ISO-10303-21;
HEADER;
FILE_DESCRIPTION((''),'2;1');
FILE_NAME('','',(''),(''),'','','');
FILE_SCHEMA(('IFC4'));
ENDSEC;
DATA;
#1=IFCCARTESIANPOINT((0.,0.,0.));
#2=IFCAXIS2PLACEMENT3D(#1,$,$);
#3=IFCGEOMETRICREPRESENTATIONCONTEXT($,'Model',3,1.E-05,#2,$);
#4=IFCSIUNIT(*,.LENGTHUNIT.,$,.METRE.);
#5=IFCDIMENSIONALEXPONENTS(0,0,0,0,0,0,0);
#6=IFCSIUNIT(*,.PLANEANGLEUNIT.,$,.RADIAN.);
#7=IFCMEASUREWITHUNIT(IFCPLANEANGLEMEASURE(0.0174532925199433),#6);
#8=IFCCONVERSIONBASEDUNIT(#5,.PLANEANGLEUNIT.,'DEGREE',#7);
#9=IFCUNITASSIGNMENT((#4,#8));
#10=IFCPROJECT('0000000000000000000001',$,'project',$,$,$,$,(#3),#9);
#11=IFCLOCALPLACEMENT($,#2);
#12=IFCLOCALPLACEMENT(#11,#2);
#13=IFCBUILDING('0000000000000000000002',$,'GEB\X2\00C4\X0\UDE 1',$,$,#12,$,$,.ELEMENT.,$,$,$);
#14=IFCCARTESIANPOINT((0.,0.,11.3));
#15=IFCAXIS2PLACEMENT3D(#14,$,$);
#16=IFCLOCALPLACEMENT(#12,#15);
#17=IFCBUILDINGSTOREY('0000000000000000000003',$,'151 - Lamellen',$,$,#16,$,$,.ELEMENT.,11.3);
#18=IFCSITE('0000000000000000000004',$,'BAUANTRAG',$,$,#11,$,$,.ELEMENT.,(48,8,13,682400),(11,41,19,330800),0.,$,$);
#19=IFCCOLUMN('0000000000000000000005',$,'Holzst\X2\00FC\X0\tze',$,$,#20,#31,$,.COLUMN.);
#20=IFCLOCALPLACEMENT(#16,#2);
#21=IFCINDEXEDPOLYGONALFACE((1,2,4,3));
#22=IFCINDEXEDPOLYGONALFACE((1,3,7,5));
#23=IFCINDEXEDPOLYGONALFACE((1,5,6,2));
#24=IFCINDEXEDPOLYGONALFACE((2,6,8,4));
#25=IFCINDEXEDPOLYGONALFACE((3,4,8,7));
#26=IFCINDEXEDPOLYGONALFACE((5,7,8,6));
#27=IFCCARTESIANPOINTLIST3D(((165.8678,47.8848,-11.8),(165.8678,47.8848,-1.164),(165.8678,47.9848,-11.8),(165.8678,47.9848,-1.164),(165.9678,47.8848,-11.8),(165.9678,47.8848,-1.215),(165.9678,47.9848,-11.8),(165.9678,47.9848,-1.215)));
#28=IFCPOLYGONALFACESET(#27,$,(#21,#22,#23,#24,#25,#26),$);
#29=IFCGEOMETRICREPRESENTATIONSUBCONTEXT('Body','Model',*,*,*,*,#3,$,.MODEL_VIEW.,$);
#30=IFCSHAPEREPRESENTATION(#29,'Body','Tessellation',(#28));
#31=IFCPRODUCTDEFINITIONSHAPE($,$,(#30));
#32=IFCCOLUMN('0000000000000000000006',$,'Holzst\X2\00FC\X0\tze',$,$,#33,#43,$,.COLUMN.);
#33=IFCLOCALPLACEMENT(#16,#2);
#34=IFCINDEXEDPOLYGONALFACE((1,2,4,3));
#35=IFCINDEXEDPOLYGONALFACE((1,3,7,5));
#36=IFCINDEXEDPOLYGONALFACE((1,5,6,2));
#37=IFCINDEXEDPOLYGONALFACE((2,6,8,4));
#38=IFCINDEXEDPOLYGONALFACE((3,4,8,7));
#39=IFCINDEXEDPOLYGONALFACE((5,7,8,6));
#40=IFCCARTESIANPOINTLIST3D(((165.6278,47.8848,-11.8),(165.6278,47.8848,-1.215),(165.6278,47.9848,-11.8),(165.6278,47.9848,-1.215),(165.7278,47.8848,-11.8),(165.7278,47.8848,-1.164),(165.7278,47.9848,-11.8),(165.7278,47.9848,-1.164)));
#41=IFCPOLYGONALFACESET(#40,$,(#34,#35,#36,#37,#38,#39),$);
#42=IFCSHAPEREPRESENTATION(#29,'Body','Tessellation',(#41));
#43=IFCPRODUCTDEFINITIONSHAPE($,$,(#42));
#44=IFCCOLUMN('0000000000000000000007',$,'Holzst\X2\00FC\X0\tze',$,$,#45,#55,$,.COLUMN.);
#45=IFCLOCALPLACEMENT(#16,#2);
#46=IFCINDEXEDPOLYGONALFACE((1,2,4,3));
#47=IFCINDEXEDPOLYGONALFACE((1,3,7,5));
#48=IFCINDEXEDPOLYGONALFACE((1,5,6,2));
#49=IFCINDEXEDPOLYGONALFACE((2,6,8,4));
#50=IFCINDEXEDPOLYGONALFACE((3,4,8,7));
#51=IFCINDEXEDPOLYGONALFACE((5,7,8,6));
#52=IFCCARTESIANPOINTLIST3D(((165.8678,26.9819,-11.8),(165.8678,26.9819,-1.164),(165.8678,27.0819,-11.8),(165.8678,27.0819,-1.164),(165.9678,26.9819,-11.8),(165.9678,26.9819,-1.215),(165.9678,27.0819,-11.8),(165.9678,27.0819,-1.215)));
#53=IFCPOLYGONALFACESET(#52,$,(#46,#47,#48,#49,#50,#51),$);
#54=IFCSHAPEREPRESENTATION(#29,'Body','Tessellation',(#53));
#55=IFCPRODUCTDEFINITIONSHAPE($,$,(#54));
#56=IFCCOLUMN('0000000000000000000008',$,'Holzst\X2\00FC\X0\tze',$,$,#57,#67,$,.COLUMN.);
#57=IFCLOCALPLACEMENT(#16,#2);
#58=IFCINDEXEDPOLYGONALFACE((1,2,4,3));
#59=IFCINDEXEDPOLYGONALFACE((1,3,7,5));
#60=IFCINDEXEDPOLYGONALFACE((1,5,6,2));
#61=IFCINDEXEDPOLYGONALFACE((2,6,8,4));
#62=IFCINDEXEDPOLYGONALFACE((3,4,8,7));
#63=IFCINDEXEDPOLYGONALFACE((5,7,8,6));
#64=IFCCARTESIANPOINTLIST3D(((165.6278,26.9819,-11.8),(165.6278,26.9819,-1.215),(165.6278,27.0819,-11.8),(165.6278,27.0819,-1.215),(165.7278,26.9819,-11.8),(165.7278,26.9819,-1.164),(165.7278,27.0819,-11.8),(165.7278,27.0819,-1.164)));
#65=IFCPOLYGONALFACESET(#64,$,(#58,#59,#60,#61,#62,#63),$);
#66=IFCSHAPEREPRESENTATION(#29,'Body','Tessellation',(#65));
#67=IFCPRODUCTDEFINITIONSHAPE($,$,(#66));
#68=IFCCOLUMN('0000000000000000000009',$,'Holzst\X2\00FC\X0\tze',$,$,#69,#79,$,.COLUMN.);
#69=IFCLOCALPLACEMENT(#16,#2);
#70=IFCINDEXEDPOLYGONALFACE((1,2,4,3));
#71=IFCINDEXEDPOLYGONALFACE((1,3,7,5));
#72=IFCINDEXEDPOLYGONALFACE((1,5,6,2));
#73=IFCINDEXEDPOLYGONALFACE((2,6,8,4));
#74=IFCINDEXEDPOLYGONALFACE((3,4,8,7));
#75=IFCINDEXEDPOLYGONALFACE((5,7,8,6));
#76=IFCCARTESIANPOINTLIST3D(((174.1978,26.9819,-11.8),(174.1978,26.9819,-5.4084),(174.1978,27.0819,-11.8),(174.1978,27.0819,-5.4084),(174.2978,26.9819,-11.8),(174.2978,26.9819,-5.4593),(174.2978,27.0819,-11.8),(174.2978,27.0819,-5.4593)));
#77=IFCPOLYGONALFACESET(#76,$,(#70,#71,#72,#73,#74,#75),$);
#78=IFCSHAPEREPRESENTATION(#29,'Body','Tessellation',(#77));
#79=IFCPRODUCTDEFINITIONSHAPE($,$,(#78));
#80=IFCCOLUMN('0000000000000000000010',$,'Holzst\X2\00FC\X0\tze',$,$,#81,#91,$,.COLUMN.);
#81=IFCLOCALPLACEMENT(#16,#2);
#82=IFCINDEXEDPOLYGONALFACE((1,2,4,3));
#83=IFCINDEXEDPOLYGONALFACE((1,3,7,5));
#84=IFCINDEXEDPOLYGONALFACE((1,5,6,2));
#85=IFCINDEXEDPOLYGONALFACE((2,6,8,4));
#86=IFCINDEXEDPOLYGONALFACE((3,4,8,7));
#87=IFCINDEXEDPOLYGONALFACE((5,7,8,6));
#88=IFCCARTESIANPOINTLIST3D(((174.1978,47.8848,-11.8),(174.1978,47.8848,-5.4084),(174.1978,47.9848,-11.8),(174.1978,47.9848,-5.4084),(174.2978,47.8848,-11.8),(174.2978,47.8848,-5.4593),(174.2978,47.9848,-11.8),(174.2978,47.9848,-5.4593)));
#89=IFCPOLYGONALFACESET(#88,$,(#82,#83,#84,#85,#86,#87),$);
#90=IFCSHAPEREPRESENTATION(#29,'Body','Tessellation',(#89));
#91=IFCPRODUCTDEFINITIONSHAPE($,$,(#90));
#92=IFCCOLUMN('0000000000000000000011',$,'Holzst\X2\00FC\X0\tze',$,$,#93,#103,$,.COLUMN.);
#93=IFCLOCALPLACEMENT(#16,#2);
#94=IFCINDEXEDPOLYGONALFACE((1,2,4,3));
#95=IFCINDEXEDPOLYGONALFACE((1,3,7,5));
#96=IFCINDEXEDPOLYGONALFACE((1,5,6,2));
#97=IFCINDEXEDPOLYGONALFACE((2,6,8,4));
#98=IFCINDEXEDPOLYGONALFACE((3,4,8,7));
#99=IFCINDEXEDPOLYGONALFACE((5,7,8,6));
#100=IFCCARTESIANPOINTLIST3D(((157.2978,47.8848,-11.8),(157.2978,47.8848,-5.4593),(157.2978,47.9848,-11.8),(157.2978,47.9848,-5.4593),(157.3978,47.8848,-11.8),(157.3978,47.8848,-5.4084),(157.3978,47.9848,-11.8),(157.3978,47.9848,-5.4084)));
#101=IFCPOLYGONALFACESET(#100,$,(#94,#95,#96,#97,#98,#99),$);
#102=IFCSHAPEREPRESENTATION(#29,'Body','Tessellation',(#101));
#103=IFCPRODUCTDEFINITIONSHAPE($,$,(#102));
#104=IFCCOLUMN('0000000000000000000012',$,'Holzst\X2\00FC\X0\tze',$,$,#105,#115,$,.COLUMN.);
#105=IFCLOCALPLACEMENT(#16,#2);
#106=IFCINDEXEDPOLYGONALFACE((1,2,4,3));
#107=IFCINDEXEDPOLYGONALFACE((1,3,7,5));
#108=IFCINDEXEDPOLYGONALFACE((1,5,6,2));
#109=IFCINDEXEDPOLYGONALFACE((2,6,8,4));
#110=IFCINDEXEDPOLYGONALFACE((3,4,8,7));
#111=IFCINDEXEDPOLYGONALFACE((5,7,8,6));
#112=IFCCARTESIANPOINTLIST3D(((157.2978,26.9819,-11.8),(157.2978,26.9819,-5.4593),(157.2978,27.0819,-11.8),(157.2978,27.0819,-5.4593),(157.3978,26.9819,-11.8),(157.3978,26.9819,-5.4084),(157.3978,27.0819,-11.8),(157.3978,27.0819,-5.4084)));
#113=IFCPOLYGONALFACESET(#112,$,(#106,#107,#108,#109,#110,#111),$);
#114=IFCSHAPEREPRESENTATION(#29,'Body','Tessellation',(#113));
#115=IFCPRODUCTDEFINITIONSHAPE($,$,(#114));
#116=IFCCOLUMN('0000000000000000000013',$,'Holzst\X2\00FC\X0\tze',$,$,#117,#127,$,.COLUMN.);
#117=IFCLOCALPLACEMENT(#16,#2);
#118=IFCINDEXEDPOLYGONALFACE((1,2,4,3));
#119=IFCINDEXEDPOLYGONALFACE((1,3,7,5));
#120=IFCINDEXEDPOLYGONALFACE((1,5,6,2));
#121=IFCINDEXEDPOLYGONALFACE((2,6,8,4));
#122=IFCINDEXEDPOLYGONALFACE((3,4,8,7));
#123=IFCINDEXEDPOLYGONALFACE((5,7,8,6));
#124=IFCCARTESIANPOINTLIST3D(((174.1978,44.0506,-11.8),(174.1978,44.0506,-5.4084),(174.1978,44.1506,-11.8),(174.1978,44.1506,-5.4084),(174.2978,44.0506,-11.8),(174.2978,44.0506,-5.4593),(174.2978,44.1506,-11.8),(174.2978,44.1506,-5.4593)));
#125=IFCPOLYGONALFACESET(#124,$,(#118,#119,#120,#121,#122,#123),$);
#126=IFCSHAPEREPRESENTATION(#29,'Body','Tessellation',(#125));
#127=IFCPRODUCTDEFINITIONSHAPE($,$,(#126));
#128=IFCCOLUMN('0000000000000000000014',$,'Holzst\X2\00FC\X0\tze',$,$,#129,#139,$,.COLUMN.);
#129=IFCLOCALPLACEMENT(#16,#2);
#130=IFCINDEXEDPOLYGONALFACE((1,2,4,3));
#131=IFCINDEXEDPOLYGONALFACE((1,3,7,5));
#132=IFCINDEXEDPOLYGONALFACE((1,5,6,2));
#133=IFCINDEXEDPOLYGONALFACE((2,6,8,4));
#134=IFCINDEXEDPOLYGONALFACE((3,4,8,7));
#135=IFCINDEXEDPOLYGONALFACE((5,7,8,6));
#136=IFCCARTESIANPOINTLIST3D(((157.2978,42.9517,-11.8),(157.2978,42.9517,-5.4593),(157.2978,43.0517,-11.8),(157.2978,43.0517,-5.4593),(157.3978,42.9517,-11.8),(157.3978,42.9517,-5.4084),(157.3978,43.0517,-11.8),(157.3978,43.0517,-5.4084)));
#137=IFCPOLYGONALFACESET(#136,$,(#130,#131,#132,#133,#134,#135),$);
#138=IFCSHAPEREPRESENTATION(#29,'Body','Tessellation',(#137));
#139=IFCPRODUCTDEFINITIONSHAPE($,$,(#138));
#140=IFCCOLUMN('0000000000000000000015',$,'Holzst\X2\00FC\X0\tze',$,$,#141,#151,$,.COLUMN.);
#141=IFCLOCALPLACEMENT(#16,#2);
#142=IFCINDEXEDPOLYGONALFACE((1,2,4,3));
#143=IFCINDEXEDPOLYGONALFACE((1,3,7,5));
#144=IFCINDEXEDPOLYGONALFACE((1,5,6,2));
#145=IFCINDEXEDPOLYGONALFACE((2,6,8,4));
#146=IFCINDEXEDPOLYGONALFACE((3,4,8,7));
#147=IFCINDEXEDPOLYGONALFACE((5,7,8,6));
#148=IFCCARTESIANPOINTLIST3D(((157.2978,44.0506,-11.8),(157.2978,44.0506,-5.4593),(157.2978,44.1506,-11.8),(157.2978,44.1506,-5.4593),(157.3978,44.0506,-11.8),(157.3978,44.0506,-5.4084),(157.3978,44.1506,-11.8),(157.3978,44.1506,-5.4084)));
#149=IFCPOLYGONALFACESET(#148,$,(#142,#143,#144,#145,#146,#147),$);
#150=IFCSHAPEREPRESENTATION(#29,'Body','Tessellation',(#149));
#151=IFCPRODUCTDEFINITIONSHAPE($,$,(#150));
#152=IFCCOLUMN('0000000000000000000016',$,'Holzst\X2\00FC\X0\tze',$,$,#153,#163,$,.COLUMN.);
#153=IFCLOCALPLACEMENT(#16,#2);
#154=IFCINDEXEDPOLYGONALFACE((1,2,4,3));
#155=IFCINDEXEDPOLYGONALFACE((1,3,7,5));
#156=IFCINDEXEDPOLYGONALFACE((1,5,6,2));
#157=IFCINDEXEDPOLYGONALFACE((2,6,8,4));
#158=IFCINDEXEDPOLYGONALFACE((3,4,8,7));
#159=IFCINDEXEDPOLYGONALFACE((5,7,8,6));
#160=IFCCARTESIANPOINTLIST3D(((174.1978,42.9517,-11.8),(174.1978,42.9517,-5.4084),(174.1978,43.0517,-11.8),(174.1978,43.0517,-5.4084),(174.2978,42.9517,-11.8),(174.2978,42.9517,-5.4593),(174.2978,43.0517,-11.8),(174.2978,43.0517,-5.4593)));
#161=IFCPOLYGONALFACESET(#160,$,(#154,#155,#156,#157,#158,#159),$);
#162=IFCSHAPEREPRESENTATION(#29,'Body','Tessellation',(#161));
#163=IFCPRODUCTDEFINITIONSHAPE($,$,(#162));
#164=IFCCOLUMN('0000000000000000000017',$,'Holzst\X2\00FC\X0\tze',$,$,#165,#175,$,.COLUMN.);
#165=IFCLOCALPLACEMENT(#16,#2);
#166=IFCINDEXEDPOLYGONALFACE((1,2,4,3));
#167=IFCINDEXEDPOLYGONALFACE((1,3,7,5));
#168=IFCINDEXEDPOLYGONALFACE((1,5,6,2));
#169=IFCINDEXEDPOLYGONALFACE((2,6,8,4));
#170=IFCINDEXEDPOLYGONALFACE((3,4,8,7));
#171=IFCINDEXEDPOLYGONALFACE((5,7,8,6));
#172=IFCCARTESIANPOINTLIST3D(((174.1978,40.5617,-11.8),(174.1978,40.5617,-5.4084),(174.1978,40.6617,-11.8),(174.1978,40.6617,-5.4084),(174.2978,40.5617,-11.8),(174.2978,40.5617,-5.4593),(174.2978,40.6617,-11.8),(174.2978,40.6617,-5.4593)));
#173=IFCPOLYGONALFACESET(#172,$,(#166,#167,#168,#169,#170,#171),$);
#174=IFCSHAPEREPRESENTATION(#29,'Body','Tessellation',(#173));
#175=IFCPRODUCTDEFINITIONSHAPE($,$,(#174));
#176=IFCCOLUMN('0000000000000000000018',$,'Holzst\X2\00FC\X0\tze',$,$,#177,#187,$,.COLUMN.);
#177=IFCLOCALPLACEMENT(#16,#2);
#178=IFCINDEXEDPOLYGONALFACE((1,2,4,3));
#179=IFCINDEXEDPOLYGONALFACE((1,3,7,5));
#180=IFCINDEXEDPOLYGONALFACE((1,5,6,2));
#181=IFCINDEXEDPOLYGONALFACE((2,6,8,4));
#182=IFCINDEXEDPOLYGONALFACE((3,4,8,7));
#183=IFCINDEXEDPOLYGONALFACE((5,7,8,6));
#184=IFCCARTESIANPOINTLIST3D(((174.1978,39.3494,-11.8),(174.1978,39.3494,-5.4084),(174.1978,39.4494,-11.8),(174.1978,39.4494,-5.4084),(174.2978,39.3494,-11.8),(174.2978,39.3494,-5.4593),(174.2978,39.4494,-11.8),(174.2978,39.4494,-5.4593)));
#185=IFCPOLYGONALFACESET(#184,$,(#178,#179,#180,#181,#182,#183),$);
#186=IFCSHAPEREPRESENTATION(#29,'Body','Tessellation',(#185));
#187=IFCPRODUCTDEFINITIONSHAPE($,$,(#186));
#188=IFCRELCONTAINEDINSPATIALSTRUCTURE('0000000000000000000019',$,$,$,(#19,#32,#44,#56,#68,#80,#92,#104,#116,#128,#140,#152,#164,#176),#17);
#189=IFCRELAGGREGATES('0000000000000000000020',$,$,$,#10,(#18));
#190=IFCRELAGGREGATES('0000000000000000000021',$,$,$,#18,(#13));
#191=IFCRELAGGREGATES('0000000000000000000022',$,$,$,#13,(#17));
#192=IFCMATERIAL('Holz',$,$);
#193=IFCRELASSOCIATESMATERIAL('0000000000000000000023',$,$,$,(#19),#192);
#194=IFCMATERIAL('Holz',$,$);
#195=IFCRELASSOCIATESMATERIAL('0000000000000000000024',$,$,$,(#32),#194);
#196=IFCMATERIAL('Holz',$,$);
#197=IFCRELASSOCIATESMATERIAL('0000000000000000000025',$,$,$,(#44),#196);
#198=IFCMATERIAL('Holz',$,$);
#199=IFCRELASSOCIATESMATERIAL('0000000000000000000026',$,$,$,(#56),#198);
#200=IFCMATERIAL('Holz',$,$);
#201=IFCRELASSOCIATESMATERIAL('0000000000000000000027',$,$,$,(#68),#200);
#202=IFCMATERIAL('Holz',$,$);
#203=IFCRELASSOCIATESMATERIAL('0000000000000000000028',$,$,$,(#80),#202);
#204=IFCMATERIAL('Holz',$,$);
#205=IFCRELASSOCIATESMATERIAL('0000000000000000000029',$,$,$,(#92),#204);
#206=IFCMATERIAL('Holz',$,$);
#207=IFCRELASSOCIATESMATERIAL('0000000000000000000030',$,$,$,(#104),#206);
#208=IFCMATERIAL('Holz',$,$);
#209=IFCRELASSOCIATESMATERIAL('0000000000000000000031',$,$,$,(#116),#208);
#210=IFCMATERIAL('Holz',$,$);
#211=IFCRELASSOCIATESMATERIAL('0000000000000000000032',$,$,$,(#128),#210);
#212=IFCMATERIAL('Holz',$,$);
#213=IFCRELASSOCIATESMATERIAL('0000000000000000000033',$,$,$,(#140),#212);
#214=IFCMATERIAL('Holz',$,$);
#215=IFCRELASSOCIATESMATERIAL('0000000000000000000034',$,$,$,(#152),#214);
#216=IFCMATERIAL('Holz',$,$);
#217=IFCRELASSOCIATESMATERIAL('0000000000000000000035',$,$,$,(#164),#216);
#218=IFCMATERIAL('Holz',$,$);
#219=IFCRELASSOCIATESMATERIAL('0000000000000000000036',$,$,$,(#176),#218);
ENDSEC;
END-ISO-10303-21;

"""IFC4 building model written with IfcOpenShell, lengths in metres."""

from ifc_helpers import new_model, entity, si_unit, converted_unit, frame, frame_2d, origin, origin_with_axes, place, context, subcontext, project, spatial, rectangle, extrude, clip, halfspace, material, element, save


model = new_model("IFC4")

# Units and contexts
model_context = context("Model", 3, precision=1e-05, world=origin())
body_context = subcontext(model_context, "Body", "Model", "MODEL_VIEW")
ifc_project = project(units=[si_unit("LENGTHUNIT", "METRE"), converted_unit("PLANEANGLEUNIT", "DEGREE", entity("IfcPlaneAngleMeasure", 0.0174532925199433), si_unit("PLANEANGLEUNIT", "RADIAN"), dimensions=[0, 0, 0, 0, 0, 0, 0])], contexts=[model_context])

# Site, building, storey
site_placement = place(None, origin())
site = spatial("IfcSite", under=ifc_project, at=site_placement, Name="BAUANTRAG", CompositionType="ELEMENT", RefLatitude=(48, 8, 13, 682400), RefLongitude=(11, 41, 19, 330800), RefElevation=0.0)
building_placement = place(site_placement, origin())
building = spatial("IfcBuilding", under=site, at=building_placement, Name="GEBÄUDE 1", CompositionType="ELEMENT")
storey_placement = place(building_placement, frame((0.0, 0.0, 11.3)))
storey = spatial("IfcBuildingStorey", under=building, at=storey_placement, Name="151 - Lamellen", CompositionType="ELEMENT", Elevation=11.3)

# Columns
ifc_material_1 = material(Name="Holz")
column_1_placement = place(storey_placement, frame((165.9678, 47.8848, -11.8)))
element("IfcColumn", 1, at=column_1_placement, inside=storey, material=ifc_material_1, Name="Holzstütze", PredefinedType="COLUMN", context=body_context, shape_type="Clipping", body=[
    clip(extrude(rectangle(XDim=0.1, YDim=0.1, at=frame_2d((-0.05, 0.05), x_axis=(0.0, 1.0))), origin_with_axes(), (0.0, 0.0, 1.0), 10.636), halfspace(frame((-0.05, 0.05, 10.6105), z_axis=(-0.45399, 0.0, -0.891007), x_axis=(0.0, 1.0, 0.0)), True)),
])
ifc_material_2 = material(Name="Holz")
column_2_placement = place(storey_placement, frame((165.7278, 47.8848, -11.8)))
element("IfcColumn", 2, at=column_2_placement, inside=storey, material=ifc_material_2, Name="Holzstütze", PredefinedType="COLUMN", context=body_context, shape_type="Clipping", body=[
    clip(extrude(rectangle(XDim=0.1, YDim=0.1, at=frame_2d((-0.05, 0.05), x_axis=(0.0, 1.0))), origin_with_axes(), (0.0, 0.0, 1.0), 10.636), halfspace(frame((-0.05, 0.05, 10.6105), z_axis=(0.45399, 0.0, -0.891007), x_axis=(0.0, 1.0, 0.0)), True)),
])
ifc_material_3 = material(Name="Holz")
column_3_placement = place(storey_placement, frame((165.9678, 26.9819, -11.8)))
element("IfcColumn", 3, at=column_3_placement, inside=storey, material=ifc_material_3, Name="Holzstütze", PredefinedType="COLUMN", context=body_context, shape_type="Clipping", body=[
    clip(extrude(rectangle(XDim=0.1, YDim=0.1, at=frame_2d((-0.05, 0.05), x_axis=(0.0, 1.0))), origin_with_axes(), (0.0, 0.0, 1.0), 10.636), halfspace(frame((-0.05, 0.05, 10.6105), z_axis=(-0.45399, 0.0, -0.891007), x_axis=(0.0, -1.0, 0.0)), True)),
])
ifc_material_4 = material(Name="Holz")
column_4_placement = place(storey_placement, frame((165.7278, 26.9819, -11.8)))
element("IfcColumn", 4, at=column_4_placement, inside=storey, material=ifc_material_4, Name="Holzstütze", PredefinedType="COLUMN", context=body_context, shape_type="Clipping", body=[
    clip(extrude(rectangle(XDim=0.1, YDim=0.1, at=frame_2d((-0.05, 0.05), x_axis=(0.0, 1.0))), origin_with_axes(), (0.0, 0.0, 1.0), 10.636), halfspace(frame((-0.05, 0.05, 10.6105), z_axis=(0.45399, 0.0, -0.891007), x_axis=(0.0, -1.0, 0.0)), True)),
])
ifc_material_5 = material(Name="Holz")
column_5_placement = place(storey_placement, frame((174.2978, 26.9819, -11.8)))
element("IfcColumn", 5, at=column_5_placement, inside=storey, material=ifc_material_5, Name="Holzstütze", PredefinedType="COLUMN", context=body_context, shape_type="Clipping", body=[
    clip(extrude(rectangle(XDim=0.1, YDim=0.1, at=frame_2d((-0.05, 0.05), x_axis=(0.0, 1.0))), origin_with_axes(), (0.0, 0.0, 1.0), 6.3916), halfspace(frame((-0.05, 0.05, 6.3661), z_axis=(-0.45399, 0.0, -0.891007), x_axis=(0.0, -1.0, 0.0)), True)),
])
ifc_material_6 = material(Name="Holz")
column_6_placement = place(storey_placement, frame((174.2978, 47.8848, -11.8)))
element("IfcColumn", 6, at=column_6_placement, inside=storey, material=ifc_material_6, Name="Holzstütze", PredefinedType="COLUMN", context=body_context, shape_type="Clipping", body=[
    clip(extrude(rectangle(XDim=0.1, YDim=0.1, at=frame_2d((-0.05, 0.05), x_axis=(0.0, 1.0))), origin_with_axes(), (0.0, 0.0, 1.0), 6.3916), halfspace(frame((-0.05, 0.05, 6.3661), z_axis=(-0.45399, 0.0, -0.891007), x_axis=(0.891007, 0.0, -0.45399)), True)),
])
ifc_material_7 = material(Name="Holz")
column_7_placement = place(storey_placement, frame((157.3978, 47.8848, -11.8)))
element("IfcColumn", 7, at=column_7_placement, inside=storey, material=ifc_material_7, Name="Holzstütze", PredefinedType="COLUMN", context=body_context, shape_type="Clipping", body=[
    clip(extrude(rectangle(XDim=0.1, YDim=0.1, at=frame_2d((-0.05, 0.05), x_axis=(0.0, 1.0))), origin_with_axes(), (0.0, 0.0, 1.0), 6.3916), halfspace(frame((-0.05, 0.05, 6.3661), z_axis=(0.45399, 0.0, -0.891007), x_axis=(0.0, 1.0, 0.0)), True)),
])
ifc_material_8 = material(Name="Holz")
column_8_placement = place(storey_placement, frame((157.3978, 26.9819, -11.8)))
element("IfcColumn", 8, at=column_8_placement, inside=storey, material=ifc_material_8, Name="Holzstütze", PredefinedType="COLUMN", context=body_context, shape_type="Clipping", body=[
    clip(extrude(rectangle(XDim=0.1, YDim=0.1, at=frame_2d((-0.05, 0.05), x_axis=(0.0, 1.0))), origin_with_axes(), (0.0, 0.0, 1.0), 6.3916), halfspace(frame((-0.05, 0.05, 6.3661), z_axis=(0.45399, 0.0, -0.891007), x_axis=(-0.891007, 0.0, -0.45399)), True)),
])
ifc_material_9 = material(Name="Holz")
column_9_placement = place(storey_placement, frame((174.2978, 44.0506, -11.8)))
element("IfcColumn", 9, at=column_9_placement, inside=storey, material=ifc_material_9, Name="Holzstütze", PredefinedType="COLUMN", context=body_context, shape_type="Clipping", body=[
    clip(extrude(rectangle(XDim=0.1, YDim=0.1, at=frame_2d((-0.05, 0.05), x_axis=(0.0, 1.0))), origin_with_axes(), (0.0, 0.0, 1.0), 6.3916), halfspace(frame((-0.05, 0.05, 6.3661), z_axis=(-0.45399, 0.0, -0.891007), x_axis=(0.891007, 0.0, -0.45399)), True)),
])
ifc_material_10 = material(Name="Holz")
column_10_placement = place(storey_placement, frame((157.3978, 42.9517, -11.8)))
element("IfcColumn", 10, at=column_10_placement, inside=storey, material=ifc_material_10, Name="Holzstütze", PredefinedType="COLUMN", context=body_context, shape_type="Clipping", body=[
    clip(extrude(rectangle(XDim=0.1, YDim=0.1, at=frame_2d((-0.05, 0.05), x_axis=(0.0, 1.0))), origin_with_axes(), (0.0, 0.0, 1.0), 6.3916), halfspace(frame((-0.05, 0.05, 6.3661), z_axis=(0.45399, 0.0, -0.891007), x_axis=(-0.891007, 0.0, -0.45399)), True)),
])
ifc_material_11 = material(Name="Holz")
column_11_placement = place(storey_placement, frame((157.3978, 44.0506, -11.8)))
element("IfcColumn", 11, at=column_11_placement, inside=storey, material=ifc_material_11, Name="Holzstütze", PredefinedType="COLUMN", context=body_context, shape_type="Clipping", body=[
    clip(extrude(rectangle(XDim=0.1, YDim=0.1, at=frame_2d((-0.05, 0.05), x_axis=(0.0, 1.0))), origin_with_axes(), (0.0, 0.0, 1.0), 6.3916), halfspace(frame((-0.05, 0.05, 6.3661), z_axis=(0.45399, 0.0, -0.891007), x_axis=(-0.891007, 0.0, -0.45399)), True)),
])
ifc_material_12 = material(Name="Holz")
column_12_placement = place(storey_placement, frame((174.2978, 42.9517, -11.8)))
element("IfcColumn", 12, at=column_12_placement, inside=storey, material=ifc_material_12, Name="Holzstütze", PredefinedType="COLUMN", context=body_context, shape_type="Clipping", body=[
    clip(extrude(rectangle(XDim=0.1, YDim=0.1, at=frame_2d((-0.05, 0.05), x_axis=(0.0, 1.0))), origin_with_axes(), (0.0, 0.0, 1.0), 6.3916), halfspace(frame((-0.05, 0.05, 6.3661), z_axis=(-0.45399, 0.0, -0.891007), x_axis=(0.891007, 0.0, -0.45399)), True)),
])
ifc_material_13 = material(Name="Holz")
column_13_placement = place(storey_placement, frame((174.2978, 40.5617, -11.8)))
element("IfcColumn", 13, at=column_13_placement, inside=storey, material=ifc_material_13, Name="Holzstütze", PredefinedType="COLUMN", context=body_context, shape_type="Clipping", body=[
    clip(extrude(rectangle(XDim=0.1, YDim=0.1, at=frame_2d((-0.05, 0.05), x_axis=(0.0, 1.0))), origin_with_axes(), (0.0, 0.0, 1.0), 6.3916), halfspace(frame((-0.05, 0.05, 6.3661), z_axis=(-0.45399, 0.0, -0.891007), x_axis=(0.891007, 0.0, -0.45399)), True)),
])
ifc_material_14 = material(Name="Holz")
column_14_placement = place(storey_placement, frame((174.2978, 39.3494, -11.8)))
element("IfcColumn", 14, at=column_14_placement, inside=storey, material=ifc_material_14, Name="Holzstütze", PredefinedType="COLUMN", context=body_context, shape_type="Clipping", body=[
    clip(extrude(rectangle(XDim=0.1, YDim=0.1, at=frame_2d((-0.05, 0.05), x_axis=(0.0, 1.0))), origin_with_axes(), (0.0, 0.0, 1.0), 6.3916), halfspace(frame((-0.05, 0.05, 6.3661), z_axis=(-0.45399, 0.0, -0.891007), x_axis=(0.891007, 0.0, -0.45399)), True)),
])

save(model, "model.ifc")
